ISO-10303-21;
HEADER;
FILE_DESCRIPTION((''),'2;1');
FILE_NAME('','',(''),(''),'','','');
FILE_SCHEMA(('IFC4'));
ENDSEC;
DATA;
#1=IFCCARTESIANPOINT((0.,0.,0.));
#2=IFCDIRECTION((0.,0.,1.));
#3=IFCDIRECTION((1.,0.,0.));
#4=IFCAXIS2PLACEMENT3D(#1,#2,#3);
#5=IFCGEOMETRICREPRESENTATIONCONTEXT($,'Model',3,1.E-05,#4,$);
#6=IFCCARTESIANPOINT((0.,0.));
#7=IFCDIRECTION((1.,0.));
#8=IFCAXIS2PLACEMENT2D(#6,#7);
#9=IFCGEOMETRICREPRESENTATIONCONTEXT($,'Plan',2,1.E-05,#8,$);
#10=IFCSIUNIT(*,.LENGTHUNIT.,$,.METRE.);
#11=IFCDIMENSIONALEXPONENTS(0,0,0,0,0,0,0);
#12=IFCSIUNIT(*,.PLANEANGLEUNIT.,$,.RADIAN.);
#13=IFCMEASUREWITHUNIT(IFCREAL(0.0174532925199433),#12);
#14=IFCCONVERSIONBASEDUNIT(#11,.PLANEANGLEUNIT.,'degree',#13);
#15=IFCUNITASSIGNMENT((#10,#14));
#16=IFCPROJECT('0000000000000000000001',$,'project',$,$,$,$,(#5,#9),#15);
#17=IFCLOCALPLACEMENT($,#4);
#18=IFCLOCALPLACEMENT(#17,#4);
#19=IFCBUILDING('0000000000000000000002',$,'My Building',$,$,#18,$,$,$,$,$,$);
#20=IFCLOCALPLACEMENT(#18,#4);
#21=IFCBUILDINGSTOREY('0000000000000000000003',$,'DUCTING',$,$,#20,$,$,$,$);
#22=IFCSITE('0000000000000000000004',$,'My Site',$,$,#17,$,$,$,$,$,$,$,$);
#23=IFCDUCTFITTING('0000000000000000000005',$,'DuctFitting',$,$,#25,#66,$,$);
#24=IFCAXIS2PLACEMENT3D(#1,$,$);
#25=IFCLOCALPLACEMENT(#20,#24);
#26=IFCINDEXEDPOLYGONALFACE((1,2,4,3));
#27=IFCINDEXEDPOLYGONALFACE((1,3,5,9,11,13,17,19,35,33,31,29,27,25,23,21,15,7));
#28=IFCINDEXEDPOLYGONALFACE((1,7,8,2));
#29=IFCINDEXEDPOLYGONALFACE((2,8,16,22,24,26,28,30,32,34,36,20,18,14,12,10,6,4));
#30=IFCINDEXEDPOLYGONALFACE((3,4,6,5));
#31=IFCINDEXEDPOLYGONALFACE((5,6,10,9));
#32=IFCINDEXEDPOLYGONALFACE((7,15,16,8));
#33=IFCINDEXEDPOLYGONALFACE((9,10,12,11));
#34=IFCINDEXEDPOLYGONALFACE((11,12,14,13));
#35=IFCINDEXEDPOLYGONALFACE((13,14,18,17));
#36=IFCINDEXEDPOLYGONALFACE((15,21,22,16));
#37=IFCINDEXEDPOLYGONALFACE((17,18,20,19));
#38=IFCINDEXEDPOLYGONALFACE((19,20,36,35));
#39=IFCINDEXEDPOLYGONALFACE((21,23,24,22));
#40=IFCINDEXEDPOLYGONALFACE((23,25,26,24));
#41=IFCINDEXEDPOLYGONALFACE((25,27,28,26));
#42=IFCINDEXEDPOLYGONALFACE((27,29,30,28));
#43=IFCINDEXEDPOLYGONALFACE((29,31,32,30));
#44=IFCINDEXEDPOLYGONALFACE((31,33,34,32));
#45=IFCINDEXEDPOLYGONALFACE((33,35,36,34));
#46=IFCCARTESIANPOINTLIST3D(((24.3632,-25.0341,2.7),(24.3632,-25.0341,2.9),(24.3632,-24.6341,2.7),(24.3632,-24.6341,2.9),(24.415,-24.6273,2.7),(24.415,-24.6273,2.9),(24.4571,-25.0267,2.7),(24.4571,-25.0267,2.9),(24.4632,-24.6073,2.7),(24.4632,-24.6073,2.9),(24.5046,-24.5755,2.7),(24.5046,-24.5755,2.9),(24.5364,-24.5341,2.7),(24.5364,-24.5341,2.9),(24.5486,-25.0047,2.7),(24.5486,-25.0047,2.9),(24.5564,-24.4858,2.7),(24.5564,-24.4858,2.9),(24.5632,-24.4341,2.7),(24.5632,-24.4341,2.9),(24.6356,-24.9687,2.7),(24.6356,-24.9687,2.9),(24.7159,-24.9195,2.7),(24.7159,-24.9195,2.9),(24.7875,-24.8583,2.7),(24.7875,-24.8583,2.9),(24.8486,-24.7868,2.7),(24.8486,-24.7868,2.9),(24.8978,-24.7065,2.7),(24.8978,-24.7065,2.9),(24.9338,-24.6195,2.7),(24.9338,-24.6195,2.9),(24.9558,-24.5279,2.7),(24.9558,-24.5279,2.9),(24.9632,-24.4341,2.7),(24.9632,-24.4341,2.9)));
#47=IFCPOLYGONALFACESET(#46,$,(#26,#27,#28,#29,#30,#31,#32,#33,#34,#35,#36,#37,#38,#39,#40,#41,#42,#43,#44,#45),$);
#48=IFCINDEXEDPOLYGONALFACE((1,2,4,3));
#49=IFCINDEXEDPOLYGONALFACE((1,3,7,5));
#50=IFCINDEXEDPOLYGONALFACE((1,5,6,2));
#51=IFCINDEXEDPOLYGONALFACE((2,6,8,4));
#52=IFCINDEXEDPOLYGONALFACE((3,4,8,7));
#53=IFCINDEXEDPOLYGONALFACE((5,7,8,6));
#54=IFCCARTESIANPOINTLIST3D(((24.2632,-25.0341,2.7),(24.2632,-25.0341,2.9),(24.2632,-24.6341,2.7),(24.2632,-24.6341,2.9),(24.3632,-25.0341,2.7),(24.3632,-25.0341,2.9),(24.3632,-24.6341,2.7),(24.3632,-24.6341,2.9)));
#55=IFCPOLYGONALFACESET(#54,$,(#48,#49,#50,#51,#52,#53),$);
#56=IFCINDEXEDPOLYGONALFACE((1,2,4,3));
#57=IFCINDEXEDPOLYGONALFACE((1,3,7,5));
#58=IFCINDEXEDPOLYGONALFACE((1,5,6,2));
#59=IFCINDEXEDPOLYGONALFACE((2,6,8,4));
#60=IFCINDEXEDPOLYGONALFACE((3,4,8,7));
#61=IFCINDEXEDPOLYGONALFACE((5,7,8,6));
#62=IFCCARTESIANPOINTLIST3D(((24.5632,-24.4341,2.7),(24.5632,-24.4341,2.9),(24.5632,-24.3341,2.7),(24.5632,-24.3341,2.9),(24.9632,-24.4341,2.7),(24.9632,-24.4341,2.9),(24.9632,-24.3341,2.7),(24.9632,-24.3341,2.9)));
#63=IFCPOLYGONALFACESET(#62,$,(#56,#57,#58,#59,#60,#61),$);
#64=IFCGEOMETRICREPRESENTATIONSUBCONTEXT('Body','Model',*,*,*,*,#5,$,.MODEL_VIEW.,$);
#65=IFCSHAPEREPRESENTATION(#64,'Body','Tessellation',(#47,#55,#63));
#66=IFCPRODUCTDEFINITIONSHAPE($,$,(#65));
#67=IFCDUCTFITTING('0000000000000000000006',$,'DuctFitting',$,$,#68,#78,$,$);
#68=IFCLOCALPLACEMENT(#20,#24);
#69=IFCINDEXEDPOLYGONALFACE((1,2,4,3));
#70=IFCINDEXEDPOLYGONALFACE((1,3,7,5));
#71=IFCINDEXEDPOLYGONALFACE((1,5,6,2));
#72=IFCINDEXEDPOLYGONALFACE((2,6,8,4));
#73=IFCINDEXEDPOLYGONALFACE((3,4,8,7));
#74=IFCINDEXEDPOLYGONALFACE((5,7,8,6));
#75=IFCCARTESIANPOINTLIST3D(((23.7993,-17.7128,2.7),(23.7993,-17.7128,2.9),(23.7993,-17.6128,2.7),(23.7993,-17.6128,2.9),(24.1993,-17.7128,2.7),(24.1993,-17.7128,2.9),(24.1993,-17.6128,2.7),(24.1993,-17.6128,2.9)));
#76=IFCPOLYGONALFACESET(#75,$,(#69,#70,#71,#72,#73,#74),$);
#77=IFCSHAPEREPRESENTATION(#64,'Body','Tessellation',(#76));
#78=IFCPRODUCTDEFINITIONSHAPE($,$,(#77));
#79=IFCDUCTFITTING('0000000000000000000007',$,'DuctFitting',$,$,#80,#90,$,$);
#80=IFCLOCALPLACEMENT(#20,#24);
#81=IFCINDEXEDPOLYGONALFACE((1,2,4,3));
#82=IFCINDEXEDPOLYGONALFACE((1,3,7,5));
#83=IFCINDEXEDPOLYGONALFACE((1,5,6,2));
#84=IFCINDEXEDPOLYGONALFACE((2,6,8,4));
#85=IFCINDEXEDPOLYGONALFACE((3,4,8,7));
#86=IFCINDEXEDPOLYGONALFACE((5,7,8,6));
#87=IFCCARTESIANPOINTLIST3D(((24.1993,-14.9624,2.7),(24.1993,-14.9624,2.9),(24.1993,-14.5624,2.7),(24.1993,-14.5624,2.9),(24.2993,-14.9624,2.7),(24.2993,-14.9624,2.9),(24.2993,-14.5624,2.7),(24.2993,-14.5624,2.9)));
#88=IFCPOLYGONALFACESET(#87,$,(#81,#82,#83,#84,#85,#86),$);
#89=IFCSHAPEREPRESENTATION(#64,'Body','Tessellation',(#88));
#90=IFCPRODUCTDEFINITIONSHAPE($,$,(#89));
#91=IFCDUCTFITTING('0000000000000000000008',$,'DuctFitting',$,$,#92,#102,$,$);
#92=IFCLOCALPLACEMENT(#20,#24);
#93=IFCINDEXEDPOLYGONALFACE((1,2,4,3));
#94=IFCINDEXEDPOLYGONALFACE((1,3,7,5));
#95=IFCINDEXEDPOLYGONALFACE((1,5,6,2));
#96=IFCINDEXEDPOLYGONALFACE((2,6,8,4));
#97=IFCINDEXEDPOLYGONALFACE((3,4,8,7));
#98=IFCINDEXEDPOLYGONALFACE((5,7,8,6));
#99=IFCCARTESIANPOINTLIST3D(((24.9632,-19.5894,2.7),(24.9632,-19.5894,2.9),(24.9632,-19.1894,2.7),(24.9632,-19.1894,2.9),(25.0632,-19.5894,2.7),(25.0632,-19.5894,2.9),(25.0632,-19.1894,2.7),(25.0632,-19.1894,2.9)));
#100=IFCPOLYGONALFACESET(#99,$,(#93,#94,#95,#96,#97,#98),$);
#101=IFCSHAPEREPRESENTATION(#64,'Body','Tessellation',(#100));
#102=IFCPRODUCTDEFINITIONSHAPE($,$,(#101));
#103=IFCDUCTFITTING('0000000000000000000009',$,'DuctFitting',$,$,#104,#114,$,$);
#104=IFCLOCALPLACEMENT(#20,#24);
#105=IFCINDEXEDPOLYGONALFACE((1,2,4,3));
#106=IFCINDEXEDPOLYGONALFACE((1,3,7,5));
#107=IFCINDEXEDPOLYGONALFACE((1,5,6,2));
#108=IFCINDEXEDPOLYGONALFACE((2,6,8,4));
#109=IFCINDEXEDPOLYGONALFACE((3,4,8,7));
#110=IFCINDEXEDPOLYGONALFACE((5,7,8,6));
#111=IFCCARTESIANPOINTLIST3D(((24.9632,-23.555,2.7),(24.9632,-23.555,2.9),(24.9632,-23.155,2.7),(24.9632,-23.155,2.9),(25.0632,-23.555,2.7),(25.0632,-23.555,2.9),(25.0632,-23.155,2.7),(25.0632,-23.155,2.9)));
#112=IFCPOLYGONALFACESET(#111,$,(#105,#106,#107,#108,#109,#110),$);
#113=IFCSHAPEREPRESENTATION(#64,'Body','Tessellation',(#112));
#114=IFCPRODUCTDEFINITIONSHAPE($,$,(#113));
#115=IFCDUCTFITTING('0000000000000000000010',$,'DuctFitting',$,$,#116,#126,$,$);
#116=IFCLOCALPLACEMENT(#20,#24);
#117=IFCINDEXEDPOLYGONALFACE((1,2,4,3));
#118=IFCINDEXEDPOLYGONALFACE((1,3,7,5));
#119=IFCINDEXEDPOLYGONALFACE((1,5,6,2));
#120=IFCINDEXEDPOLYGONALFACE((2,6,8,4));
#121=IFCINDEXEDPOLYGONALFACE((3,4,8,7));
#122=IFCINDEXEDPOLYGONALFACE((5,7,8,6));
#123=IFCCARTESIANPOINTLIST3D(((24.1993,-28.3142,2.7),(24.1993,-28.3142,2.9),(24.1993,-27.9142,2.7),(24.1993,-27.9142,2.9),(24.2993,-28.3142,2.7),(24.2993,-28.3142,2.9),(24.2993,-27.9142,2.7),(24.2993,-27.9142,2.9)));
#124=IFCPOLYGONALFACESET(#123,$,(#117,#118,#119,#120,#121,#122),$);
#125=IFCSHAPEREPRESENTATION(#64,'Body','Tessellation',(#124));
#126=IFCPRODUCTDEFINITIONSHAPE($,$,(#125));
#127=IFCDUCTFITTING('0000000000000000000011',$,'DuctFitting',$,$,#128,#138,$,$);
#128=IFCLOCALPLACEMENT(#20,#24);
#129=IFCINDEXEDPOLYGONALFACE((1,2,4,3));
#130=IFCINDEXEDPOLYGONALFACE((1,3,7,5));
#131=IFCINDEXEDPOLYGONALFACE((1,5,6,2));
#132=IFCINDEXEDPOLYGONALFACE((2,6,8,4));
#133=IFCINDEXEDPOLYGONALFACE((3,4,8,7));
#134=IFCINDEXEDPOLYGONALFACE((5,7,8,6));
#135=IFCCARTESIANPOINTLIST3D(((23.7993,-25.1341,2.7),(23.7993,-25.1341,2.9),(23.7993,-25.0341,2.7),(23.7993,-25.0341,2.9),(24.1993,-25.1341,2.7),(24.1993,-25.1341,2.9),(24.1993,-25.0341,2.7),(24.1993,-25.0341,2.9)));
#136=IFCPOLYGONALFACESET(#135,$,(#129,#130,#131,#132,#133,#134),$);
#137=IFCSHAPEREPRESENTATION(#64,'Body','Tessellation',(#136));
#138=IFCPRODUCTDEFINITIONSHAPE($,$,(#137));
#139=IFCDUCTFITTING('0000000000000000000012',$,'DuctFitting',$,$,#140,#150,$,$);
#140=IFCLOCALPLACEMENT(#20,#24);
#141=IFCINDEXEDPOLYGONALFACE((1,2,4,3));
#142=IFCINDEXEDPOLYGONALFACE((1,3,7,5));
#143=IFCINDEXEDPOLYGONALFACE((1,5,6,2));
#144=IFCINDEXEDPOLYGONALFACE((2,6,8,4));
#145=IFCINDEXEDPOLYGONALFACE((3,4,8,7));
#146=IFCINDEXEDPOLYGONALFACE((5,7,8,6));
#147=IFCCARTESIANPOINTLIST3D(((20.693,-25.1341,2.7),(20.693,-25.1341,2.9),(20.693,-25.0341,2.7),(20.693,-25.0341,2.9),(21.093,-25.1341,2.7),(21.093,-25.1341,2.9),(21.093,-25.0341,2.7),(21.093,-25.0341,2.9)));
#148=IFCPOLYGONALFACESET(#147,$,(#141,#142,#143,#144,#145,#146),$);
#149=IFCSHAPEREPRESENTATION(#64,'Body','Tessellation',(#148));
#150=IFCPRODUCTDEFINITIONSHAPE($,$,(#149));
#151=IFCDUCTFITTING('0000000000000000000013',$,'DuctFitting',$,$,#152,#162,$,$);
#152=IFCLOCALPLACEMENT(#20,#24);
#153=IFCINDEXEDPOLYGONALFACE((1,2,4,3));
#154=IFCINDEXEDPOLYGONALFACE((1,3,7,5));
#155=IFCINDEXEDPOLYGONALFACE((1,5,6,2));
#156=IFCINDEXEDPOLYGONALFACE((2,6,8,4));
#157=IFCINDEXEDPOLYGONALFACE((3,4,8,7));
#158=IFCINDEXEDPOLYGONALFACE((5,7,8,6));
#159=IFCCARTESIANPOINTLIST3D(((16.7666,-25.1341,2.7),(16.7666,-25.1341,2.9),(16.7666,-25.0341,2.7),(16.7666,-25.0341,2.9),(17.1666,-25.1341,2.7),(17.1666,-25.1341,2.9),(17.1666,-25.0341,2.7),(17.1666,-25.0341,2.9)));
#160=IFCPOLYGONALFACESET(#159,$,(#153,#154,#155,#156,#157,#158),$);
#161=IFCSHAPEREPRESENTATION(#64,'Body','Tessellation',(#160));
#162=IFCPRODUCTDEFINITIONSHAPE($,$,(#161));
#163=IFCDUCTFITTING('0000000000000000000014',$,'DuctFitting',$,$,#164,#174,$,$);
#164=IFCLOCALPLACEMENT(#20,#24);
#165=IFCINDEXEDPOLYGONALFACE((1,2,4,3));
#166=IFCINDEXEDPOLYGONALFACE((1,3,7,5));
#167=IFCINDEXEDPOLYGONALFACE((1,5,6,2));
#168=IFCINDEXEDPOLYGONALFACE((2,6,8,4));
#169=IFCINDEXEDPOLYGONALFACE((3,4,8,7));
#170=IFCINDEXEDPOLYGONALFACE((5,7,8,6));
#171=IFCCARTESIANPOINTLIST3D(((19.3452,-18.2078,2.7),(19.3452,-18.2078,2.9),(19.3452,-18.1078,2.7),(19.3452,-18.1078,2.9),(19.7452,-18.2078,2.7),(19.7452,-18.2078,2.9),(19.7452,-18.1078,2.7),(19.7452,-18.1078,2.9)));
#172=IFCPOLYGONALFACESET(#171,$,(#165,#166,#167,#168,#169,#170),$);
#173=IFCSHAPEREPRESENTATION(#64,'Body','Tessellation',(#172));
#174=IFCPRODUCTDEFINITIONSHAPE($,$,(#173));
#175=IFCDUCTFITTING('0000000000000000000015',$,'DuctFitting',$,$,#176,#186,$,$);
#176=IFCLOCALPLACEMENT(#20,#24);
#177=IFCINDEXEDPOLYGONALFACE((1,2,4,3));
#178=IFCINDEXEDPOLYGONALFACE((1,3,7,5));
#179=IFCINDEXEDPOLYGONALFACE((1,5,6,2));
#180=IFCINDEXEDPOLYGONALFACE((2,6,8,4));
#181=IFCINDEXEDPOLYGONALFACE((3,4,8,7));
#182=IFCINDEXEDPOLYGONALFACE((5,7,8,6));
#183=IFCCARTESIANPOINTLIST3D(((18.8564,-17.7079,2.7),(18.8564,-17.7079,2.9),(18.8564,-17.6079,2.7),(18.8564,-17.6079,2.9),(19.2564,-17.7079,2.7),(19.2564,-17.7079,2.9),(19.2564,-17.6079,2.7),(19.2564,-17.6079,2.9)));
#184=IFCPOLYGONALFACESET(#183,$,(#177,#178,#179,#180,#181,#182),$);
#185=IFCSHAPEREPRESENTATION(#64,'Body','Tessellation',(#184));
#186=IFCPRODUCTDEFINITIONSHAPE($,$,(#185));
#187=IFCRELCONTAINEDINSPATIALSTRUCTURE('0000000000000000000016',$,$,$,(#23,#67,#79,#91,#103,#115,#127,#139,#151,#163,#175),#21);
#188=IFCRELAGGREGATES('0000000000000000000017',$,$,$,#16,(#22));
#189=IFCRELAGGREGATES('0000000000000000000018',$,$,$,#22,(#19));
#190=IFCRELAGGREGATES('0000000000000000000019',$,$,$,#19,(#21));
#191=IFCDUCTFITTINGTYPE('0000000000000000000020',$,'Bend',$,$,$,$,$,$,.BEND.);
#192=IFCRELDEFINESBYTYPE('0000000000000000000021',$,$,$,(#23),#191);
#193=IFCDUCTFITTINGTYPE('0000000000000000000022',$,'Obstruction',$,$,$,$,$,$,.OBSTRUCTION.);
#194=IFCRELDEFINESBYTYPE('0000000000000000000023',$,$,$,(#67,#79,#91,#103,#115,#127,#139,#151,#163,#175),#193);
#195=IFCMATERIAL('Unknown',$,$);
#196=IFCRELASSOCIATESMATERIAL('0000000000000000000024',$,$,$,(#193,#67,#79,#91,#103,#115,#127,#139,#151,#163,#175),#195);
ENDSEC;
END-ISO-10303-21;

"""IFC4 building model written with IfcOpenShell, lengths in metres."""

from ifc_helpers import new_model, entity, si_unit, converted_unit, frame, origin_with_axes, origin_2d_with_axis, place, context, subcontext, project, spatial, line, arc, indexed_curve, rectangle, outline, extrude, source, transform, mapped, material, material_profile, profile_set, profile_usage, type_object, type_shapes, element, save


model = new_model("IFC4")

# Units and contexts
model_context = context("Model", 3, precision=1e-05, world=origin_with_axes())
plan_context = context("Plan", 2, precision=1e-05, world=origin_2d_with_axis())
body_context = subcontext(model_context, "Body", "Model", "MODEL_VIEW")
ifc_project = project(units=[si_unit("LENGTHUNIT", "METRE"), converted_unit("PLANEANGLEUNIT", "degree", entity("IfcReal", 0.0174532925199433), si_unit("PLANEANGLEUNIT", "RADIAN"), dimensions=[0, 0, 0, 0, 0, 0, 0])], contexts=[model_context, plan_context])

# Site, building, storey
site_placement = place(None, origin_with_axes())
site = spatial("IfcSite", under=ifc_project, at=site_placement, Name="My Site")
building_placement = place(site_placement, origin_with_axes())
building = spatial("IfcBuilding", under=site, at=building_placement, Name="My Building")
storey_placement = place(building_placement, origin_with_axes())
storey = spatial("IfcBuildingStorey", under=building, at=storey_placement, Name="DUCTING")

# Shared definitions
ifc_material = material(Name="Unknown")

# Duct fittings
duct_fitting_type_1 = type_object("IfcDuctFittingType", Name="Bend", PredefinedType="BEND")
shared_shape = source(origin_with_axes(), body_context, "Body", "SweptSolid", [
    extrude(outline(indexed_curve([(-0.2, 0.0), (-0.2586, 0.1414), (-0.4, 0.2), (-0.4, 0.6), (0.0243, 0.4243), (0.2, 0.0)], segments=[arc(1, 2, 3), line(3, 4), arc(4, 5, 6), line(6, 1)])), frame((0.0, -0.1, 0.1), z_axis=(0.0, -1.0, 0.0), x_axis=(1.0, 0.0, 0.0)), (0.0, 0.0, -1.0), 0.2),
    extrude(rectangle(XDim=0.4, YDim=0.2), origin_with_axes(), (0.0, 0.0, 1.0), 0.1),
    extrude(rectangle(XDim=0.4, YDim=0.2), frame((-0.4, 0.0, 0.5), z_axis=(-1.0, 0.0, 0.0), x_axis=(0.0, 0.0, -1.0)), (0.0, 0.0, 1.0), 0.1),
])
type_shapes(duct_fitting_type_1, [shared_shape])
for number, where, z_axis, x_axis, name in (
    (1, (24.2632, -24.8341, 2.8), (1.0, 0.0, 0.0), (0.0, -1.0, 0.0), "DuctFitting"),
):
    element("IfcDuctFitting", number, at=place(storey_placement, frame(where, z_axis=z_axis, x_axis=x_axis)), inside=storey, type_object=duct_fitting_type_1, Name=name, context=body_context, shape_type="MappedRepresentation", body=[
        mapped(shared_shape, transform((0.0, 0.0, 0.0), x_axis=(1.0, 0.0, 0.0), y_axis=(0.0, 1.0, 0.0), z_axis=(0.0, 0.0, 1.0), scale=1.0)),
    ])
ifc_material_profile_1 = material_profile(ifc_material, rectangle(XDim=0.4, YDim=0.2))
ifc_profile_set_1 = profile_set([ifc_material_profile_1])
ifc_profile_usage_1 = profile_usage(ifc_profile_set_1, cardinal=5)
duct_fitting_type_2 = type_object("IfcDuctFittingType", Name="Obstruction", PredefinedType="OBSTRUCTION", material=ifc_profile_set_1)
duct_fitting_1_placement = place(storey_placement, frame((23.9993, -17.6128, 2.8), z_axis=(0.0, -1.0, 0.0), x_axis=(1.0, 0.0, 0.0)))
element("IfcDuctFitting", 2, at=duct_fitting_1_placement, inside=storey, type_object=duct_fitting_type_2, material=ifc_profile_usage_1, Name="DuctFitting", context=body_context, shape_type="SweptSolid", body=[
    extrude(rectangle(XDim=0.4, YDim=0.2), origin_with_axes(), (0.0, 0.0, 1.0), 0.1),
])
ifc_profile_usage_2 = profile_usage(ifc_profile_set_1, cardinal=5)
duct_fitting_2_placement = place(storey_placement, frame((24.2993, -14.7624, 2.8), z_axis=(-1.0, 0.0, 0.0), x_axis=(0.0, -1.0, 0.0)))
element("IfcDuctFitting", 3, at=duct_fitting_2_placement, inside=storey, type_object=duct_fitting_type_2, material=ifc_profile_usage_2, Name="DuctFitting", context=body_context, shape_type="SweptSolid", body=[
    extrude(rectangle(XDim=0.4, YDim=0.2), origin_with_axes(), (0.0, 0.0, 1.0), 0.1),
])
ifc_profile_usage_3 = profile_usage(ifc_profile_set_1, cardinal=5)
duct_fitting_3_placement = place(storey_placement, frame((25.0632, -19.3894, 2.8), z_axis=(-1.0, 0.0, 0.0), x_axis=(0.0, -1.0, 0.0)))
element("IfcDuctFitting", 4, at=duct_fitting_3_placement, inside=storey, type_object=duct_fitting_type_2, material=ifc_profile_usage_3, Name="DuctFitting", context=body_context, shape_type="SweptSolid", body=[
    extrude(rectangle(XDim=0.4, YDim=0.2), origin_with_axes(), (0.0, 0.0, 1.0), 0.1),
])
ifc_profile_usage_4 = profile_usage(ifc_profile_set_1, cardinal=5)
duct_fitting_4_placement = place(storey_placement, frame((25.0632, -23.355, 2.8), z_axis=(-1.0, 0.0, 0.0), x_axis=(0.0, -1.0, 0.0)))
element("IfcDuctFitting", 5, at=duct_fitting_4_placement, inside=storey, type_object=duct_fitting_type_2, material=ifc_profile_usage_4, Name="DuctFitting", context=body_context, shape_type="SweptSolid", body=[
    extrude(rectangle(XDim=0.4, YDim=0.2), origin_with_axes(), (0.0, 0.0, 1.0), 0.1),
])
ifc_profile_usage_5 = profile_usage(ifc_profile_set_1, cardinal=5)
duct_fitting_5_placement = place(storey_placement, frame((24.2993, -28.1142, 2.8), z_axis=(-1.0, 0.0, 0.0), x_axis=(0.0, -1.0, 0.0)))
element("IfcDuctFitting", 6, at=duct_fitting_5_placement, inside=storey, type_object=duct_fitting_type_2, material=ifc_profile_usage_5, Name="DuctFitting", context=body_context, shape_type="SweptSolid", body=[
    extrude(rectangle(XDim=0.4, YDim=0.2), origin_with_axes(), (0.0, 0.0, 1.0), 0.1),
])
ifc_profile_usage_6 = profile_usage(ifc_profile_set_1, cardinal=5)
duct_fitting_6_placement = place(storey_placement, frame((23.9993, -25.1341, 2.8), z_axis=(0.0, 1.0, 0.0), x_axis=(-1.0, 0.0, 0.0)))
element("IfcDuctFitting", 7, at=duct_fitting_6_placement, inside=storey, type_object=duct_fitting_type_2, material=ifc_profile_usage_6, Name="DuctFitting", context=body_context, shape_type="SweptSolid", body=[
    extrude(rectangle(XDim=0.4, YDim=0.2), origin_with_axes(), (0.0, 0.0, 1.0), 0.1),
])
ifc_profile_usage_7 = profile_usage(ifc_profile_set_1, cardinal=5)
duct_fitting_7_placement = place(storey_placement, frame((20.893, -25.1341, 2.8), z_axis=(0.0, 1.0, 0.0), x_axis=(-1.0, 0.0, 0.0)))
element("IfcDuctFitting", 8, at=duct_fitting_7_placement, inside=storey, type_object=duct_fitting_type_2, material=ifc_profile_usage_7, Name="DuctFitting", context=body_context, shape_type="SweptSolid", body=[
    extrude(rectangle(XDim=0.4, YDim=0.2), origin_with_axes(), (0.0, 0.0, 1.0), 0.1),
])
ifc_profile_usage_8 = profile_usage(ifc_profile_set_1, cardinal=5)
duct_fitting_8_placement = place(storey_placement, frame((16.9666, -25.1341, 2.8), z_axis=(0.0, 1.0, 0.0), x_axis=(-1.0, 0.0, 0.0)))
element("IfcDuctFitting", 9, at=duct_fitting_8_placement, inside=storey, type_object=duct_fitting_type_2, material=ifc_profile_usage_8, Name="DuctFitting", context=body_context, shape_type="SweptSolid", body=[
    extrude(rectangle(XDim=0.4, YDim=0.2), origin_with_axes(), (0.0, 0.0, 1.0), 0.1),
])
ifc_profile_usage_9 = profile_usage(ifc_profile_set_1, cardinal=5)
duct_fitting_9_placement = place(storey_placement, frame((19.5452, -18.2078, 2.8), z_axis=(0.0, 1.0, 0.0), x_axis=(-1.0, 0.0, 0.0)))
element("IfcDuctFitting", 10, at=duct_fitting_9_placement, inside=storey, type_object=duct_fitting_type_2, material=ifc_profile_usage_9, Name="DuctFitting", context=body_context, shape_type="SweptSolid", body=[
    extrude(rectangle(XDim=0.4, YDim=0.2), origin_with_axes(), (0.0, 0.0, 1.0), 0.1),
])
ifc_profile_usage_10 = profile_usage(ifc_profile_set_1, cardinal=5)
duct_fitting_10_placement = place(storey_placement, frame((19.0564, -17.6079, 2.8), z_axis=(0.0, -1.0, 0.0), x_axis=(1.0, 0.0, 0.0)))
element("IfcDuctFitting", 11, at=duct_fitting_10_placement, inside=storey, type_object=duct_fitting_type_2, material=ifc_profile_usage_10, Name="DuctFitting", context=body_context, shape_type="SweptSolid", body=[
    extrude(rectangle(XDim=0.4, YDim=0.2), origin_with_axes(), (0.0, 0.0, 1.0), 0.1),
])

save(model, "model.ifc")
